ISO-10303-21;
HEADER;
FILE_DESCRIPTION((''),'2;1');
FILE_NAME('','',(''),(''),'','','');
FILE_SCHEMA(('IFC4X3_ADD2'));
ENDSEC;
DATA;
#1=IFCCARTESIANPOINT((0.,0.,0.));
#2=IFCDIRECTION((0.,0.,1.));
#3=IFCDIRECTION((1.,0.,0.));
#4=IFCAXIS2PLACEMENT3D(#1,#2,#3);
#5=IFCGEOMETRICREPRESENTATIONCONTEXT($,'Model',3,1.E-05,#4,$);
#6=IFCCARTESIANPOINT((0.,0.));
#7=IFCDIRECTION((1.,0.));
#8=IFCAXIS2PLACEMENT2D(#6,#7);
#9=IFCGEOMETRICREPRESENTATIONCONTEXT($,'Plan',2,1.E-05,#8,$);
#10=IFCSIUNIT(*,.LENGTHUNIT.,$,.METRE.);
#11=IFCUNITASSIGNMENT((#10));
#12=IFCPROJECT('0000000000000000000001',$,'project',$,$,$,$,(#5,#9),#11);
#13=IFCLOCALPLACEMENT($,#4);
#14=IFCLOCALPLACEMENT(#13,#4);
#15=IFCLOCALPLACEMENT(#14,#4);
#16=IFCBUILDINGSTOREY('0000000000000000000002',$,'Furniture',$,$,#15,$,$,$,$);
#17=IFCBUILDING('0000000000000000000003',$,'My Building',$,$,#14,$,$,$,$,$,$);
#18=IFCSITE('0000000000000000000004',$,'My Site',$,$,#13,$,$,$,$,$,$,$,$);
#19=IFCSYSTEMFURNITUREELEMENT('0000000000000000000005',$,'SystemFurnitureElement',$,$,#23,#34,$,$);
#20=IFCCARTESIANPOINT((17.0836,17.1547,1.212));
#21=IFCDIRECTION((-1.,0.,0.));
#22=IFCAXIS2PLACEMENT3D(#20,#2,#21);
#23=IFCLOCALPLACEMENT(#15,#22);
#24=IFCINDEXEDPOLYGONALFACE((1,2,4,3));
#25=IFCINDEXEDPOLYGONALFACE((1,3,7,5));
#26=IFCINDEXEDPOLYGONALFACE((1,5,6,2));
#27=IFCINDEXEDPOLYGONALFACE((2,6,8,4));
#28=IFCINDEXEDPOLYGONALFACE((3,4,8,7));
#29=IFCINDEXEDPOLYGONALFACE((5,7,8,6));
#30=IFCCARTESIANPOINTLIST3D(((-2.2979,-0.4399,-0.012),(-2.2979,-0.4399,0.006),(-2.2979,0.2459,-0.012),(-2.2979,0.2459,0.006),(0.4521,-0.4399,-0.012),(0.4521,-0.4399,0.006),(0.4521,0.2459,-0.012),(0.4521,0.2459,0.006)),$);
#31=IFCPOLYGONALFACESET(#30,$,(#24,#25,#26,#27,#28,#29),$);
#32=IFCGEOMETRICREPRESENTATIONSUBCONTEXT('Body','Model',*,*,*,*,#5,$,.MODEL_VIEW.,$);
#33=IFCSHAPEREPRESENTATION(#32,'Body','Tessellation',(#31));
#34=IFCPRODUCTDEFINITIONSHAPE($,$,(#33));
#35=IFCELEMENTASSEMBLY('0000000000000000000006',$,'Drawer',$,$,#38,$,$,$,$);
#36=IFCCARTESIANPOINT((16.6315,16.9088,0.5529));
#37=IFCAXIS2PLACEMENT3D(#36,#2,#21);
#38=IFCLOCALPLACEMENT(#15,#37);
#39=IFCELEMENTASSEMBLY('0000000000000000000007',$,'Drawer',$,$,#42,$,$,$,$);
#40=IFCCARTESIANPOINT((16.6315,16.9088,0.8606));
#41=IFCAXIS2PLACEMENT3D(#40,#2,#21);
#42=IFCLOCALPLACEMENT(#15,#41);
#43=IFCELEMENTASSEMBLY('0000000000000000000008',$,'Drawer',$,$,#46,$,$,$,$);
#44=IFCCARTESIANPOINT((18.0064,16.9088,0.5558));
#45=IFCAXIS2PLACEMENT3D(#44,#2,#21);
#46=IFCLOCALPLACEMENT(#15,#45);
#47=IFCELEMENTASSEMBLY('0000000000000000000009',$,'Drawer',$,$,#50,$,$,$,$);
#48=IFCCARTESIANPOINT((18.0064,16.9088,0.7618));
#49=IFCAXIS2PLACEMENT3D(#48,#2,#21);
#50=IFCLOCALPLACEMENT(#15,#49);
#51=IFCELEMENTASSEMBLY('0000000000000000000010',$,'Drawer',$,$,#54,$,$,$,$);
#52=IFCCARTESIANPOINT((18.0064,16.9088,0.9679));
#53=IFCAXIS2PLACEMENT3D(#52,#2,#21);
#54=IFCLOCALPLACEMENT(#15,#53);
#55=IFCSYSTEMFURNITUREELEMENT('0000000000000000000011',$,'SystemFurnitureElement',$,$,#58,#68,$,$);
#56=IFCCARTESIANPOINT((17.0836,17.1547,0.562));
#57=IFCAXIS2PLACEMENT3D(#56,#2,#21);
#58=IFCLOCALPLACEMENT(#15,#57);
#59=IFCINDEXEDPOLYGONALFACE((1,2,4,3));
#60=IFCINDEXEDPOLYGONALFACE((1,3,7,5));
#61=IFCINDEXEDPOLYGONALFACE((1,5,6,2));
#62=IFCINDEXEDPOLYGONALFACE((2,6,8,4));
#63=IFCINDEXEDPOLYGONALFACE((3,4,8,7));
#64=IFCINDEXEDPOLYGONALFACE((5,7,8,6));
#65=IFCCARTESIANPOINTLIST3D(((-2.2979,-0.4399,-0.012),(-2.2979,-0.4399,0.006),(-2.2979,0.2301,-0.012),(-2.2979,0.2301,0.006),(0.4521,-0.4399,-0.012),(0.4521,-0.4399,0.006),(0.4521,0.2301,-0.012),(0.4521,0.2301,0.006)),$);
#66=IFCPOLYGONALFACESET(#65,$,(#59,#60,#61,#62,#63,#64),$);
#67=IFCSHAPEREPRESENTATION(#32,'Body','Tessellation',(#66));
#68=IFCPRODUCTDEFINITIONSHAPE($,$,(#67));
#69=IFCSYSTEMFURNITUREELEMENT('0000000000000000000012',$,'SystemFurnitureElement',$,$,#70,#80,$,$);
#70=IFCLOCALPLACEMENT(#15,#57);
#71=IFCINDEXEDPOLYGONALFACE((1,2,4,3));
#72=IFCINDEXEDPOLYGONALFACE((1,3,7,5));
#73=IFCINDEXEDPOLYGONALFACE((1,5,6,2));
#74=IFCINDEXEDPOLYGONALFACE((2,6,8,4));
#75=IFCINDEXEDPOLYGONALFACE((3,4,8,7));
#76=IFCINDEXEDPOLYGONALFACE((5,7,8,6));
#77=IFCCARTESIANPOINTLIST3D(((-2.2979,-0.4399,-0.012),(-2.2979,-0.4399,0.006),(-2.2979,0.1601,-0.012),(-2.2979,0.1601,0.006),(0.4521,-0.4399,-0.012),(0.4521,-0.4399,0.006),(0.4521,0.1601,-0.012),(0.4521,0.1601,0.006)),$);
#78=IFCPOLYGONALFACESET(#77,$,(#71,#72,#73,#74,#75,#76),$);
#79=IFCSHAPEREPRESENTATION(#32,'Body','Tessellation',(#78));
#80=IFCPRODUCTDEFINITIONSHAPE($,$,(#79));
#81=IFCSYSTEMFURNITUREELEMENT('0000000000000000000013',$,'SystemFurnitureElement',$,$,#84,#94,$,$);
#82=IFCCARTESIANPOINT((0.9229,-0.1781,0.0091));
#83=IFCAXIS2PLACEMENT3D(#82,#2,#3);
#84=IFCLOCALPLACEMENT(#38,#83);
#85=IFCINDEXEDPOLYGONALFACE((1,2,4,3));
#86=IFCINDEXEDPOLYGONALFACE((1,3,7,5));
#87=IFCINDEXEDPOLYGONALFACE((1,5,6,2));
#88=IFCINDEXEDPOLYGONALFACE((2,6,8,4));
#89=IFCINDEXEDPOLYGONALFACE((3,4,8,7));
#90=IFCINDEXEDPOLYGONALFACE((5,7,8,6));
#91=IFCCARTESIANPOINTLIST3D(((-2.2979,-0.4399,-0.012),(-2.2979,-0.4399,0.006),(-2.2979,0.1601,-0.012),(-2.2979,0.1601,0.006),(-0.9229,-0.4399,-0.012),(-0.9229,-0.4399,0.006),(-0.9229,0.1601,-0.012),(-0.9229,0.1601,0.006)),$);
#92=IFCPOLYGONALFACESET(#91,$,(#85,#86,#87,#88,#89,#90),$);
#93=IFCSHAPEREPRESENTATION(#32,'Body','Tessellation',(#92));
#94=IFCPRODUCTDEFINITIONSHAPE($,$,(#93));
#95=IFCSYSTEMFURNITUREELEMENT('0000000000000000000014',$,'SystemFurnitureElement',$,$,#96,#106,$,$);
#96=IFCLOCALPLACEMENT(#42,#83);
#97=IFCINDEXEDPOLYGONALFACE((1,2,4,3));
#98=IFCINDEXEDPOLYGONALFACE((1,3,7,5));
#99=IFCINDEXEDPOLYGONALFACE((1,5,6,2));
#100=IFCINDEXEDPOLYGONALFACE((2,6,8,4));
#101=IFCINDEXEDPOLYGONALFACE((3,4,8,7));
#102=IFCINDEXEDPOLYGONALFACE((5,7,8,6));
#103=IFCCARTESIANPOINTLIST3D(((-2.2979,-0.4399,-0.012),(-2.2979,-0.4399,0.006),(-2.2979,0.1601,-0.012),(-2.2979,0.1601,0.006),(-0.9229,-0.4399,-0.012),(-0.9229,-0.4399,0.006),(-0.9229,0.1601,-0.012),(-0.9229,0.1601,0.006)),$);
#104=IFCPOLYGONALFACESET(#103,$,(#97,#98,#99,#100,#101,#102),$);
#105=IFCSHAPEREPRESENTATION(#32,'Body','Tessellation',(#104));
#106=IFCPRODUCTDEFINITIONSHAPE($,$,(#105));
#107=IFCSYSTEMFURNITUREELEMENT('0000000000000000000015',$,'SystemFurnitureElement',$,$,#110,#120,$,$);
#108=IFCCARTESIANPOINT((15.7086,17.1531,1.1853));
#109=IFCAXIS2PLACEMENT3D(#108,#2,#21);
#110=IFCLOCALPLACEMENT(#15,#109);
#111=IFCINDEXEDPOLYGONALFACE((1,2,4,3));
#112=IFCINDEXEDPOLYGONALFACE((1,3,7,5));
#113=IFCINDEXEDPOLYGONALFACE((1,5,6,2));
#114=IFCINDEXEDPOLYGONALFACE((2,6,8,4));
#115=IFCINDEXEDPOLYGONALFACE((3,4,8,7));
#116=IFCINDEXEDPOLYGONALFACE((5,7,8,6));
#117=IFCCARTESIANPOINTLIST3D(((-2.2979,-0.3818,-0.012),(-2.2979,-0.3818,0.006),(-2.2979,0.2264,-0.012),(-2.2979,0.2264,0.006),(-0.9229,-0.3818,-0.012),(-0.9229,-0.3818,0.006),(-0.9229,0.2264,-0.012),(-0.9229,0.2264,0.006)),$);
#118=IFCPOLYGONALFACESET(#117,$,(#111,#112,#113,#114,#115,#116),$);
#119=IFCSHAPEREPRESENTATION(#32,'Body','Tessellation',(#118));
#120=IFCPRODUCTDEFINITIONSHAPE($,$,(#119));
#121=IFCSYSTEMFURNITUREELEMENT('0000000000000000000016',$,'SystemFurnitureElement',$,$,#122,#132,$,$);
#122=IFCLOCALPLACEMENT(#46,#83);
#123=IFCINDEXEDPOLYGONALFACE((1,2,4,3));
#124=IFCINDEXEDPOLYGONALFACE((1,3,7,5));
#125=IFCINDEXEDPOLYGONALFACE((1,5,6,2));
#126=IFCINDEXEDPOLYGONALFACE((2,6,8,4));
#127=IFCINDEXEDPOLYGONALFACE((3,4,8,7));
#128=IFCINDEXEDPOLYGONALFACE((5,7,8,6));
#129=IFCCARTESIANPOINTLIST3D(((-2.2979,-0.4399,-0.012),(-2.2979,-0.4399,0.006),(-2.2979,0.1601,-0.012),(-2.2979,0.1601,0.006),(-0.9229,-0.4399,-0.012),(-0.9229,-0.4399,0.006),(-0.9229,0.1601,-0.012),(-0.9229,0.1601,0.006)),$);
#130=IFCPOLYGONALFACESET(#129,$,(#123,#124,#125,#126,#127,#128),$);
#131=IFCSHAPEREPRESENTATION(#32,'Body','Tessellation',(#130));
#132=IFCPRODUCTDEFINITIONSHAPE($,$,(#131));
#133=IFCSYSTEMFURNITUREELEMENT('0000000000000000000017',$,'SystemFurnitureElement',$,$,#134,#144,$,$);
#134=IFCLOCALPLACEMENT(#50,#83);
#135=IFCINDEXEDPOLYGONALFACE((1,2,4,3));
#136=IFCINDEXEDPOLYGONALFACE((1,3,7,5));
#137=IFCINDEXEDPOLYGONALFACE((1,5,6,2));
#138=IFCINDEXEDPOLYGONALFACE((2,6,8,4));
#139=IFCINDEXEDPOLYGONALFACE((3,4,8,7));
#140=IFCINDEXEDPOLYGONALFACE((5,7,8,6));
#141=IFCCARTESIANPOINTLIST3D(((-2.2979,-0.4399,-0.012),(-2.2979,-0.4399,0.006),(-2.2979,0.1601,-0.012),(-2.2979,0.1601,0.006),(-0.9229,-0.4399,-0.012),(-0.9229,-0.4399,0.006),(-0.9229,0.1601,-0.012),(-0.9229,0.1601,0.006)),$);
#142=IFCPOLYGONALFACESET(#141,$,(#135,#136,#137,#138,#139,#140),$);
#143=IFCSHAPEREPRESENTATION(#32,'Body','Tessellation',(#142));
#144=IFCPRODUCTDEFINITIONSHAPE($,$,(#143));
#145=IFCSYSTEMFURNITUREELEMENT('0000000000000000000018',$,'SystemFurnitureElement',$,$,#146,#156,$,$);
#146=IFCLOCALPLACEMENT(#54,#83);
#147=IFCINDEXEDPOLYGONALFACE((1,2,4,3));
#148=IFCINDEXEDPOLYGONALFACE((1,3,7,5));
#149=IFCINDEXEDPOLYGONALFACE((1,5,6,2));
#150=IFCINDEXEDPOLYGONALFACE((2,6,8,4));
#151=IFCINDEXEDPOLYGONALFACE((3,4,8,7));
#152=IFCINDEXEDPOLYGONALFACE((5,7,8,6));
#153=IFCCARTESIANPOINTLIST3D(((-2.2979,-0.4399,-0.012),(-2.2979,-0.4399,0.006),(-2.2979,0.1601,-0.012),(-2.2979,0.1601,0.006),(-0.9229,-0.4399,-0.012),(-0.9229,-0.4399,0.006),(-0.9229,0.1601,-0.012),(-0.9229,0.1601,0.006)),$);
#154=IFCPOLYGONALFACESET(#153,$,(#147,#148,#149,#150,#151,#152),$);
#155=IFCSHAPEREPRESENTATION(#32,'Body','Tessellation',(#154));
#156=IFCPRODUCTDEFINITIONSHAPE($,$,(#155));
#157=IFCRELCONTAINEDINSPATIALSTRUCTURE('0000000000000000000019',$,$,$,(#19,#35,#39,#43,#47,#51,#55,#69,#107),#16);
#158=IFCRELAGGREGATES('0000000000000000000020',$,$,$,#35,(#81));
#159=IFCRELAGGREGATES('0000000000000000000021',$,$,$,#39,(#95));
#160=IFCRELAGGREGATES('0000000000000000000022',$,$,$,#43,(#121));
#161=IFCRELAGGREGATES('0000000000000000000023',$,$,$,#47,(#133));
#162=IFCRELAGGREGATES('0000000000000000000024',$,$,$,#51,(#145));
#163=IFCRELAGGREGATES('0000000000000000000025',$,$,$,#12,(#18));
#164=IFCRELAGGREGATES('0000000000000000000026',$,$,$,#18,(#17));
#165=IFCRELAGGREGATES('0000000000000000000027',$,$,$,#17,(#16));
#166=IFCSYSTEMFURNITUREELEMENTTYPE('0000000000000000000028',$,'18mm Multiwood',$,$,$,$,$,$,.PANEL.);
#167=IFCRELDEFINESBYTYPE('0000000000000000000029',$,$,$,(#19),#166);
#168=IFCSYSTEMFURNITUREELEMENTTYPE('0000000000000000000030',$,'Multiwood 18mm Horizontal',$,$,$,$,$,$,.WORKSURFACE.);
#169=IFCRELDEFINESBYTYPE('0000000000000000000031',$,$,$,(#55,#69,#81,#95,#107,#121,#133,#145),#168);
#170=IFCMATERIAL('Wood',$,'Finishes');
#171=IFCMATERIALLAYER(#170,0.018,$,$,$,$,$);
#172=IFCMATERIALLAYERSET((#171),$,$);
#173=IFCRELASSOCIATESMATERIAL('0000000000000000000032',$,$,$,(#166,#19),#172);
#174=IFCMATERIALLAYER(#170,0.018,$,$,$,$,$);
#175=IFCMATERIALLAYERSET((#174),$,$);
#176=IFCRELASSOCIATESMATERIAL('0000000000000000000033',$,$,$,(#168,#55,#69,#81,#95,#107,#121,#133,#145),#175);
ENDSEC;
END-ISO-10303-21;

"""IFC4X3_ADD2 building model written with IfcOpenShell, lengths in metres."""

from ifc_helpers import new_model, si_unit, frame, origin_with_axes, origin_2d_with_axis, place, context, subcontext, project, spatial, indexed_curve, outline, extrude, material, layer, layer_set, layer_usage, type_object, element, aggregate, save


model = new_model("IFC4X3_ADD2")

# Units and contexts
model_context = context("Model", 3, precision=1e-05, world=origin_with_axes())
plan_context = context("Plan", 2, precision=1e-05, world=origin_2d_with_axis())
body_context = subcontext(model_context, "Body", "Model", "MODEL_VIEW")
ifc_project = project(units=[si_unit("LENGTHUNIT", "METRE")], contexts=[model_context, plan_context])

# Site, building, storey
site_placement = place(None, origin_with_axes())
site = spatial("IfcSite", under=ifc_project, at=site_placement, Name="My Site")
building_placement = place(site_placement, origin_with_axes())
building = spatial("IfcBuilding", under=site, at=building_placement, Name="My Building")
storey_placement = place(building_placement, origin_with_axes())
storey = spatial("IfcBuildingStorey", under=building, at=storey_placement, Name="Furniture")

# System furniture element
ifc_material_1 = material(Name="Wood", Category="Finishes")
ifc_layer_1 = layer(ifc_material_1, 0.018)
ifc_layer_set_1 = layer_set([ifc_layer_1])
system_furniture_element_type_1 = type_object("IfcSystemFurnitureElementType", Name="18mm Multiwood", PredefinedType="PANEL", material=ifc_layer_set_1)
ifc_layer_usage_1 = layer_usage(ifc_layer_set_1, "AXIS3", "POSITIVE", -0.012)
system_furniture_element_1_placement = place(storey_placement, frame((17.0836, 17.1547, 1.212), z_axis=(0.0, 0.0, 1.0), x_axis=(-1.0, 0.0, 0.0)))
element("IfcSystemFurnitureElement", 1, at=system_furniture_element_1_placement, inside=storey, type_object=system_furniture_element_type_1, material=ifc_layer_usage_1, Name="SystemFurnitureElement", context=body_context, shape_type="SweptSolid", body=[
    extrude(outline(indexed_curve([(0.4521, -0.4399), (0.4521, 0.2459), (-2.2979, 0.2459), (-2.2979, -0.4399), (0.4521, -0.4399)])), frame((0.0, 0.0, -0.012), z_axis=(0.0, 0.0, 1.0), x_axis=(1.0, 0.0, 0.0)), (0.0, 0.0, 1.0), 0.018),
])

# Element assemblies
assembly_1_placement = place(storey_placement, frame((16.6315, 16.9088, 0.5529), z_axis=(0.0, 0.0, 1.0), x_axis=(-1.0, 0.0, 0.0)))
assembly_1 = element("IfcElementAssembly", 2, at=assembly_1_placement, inside=storey, Name="Drawer")
assembly_2_placement = place(storey_placement, frame((16.6315, 16.9088, 0.8606), z_axis=(0.0, 0.0, 1.0), x_axis=(-1.0, 0.0, 0.0)))
assembly_2 = element("IfcElementAssembly", 3, at=assembly_2_placement, inside=storey, Name="Drawer")

# Element assemblies
assembly_3_placement = place(storey_placement, frame((18.0064, 16.9088, 0.5558), z_axis=(0.0, 0.0, 1.0), x_axis=(-1.0, 0.0, 0.0)))
assembly_3 = element("IfcElementAssembly", 4, at=assembly_3_placement, inside=storey, Name="Drawer")
assembly_4_placement = place(storey_placement, frame((18.0064, 16.9088, 0.7618), z_axis=(0.0, 0.0, 1.0), x_axis=(-1.0, 0.0, 0.0)))
assembly_4 = element("IfcElementAssembly", 5, at=assembly_4_placement, inside=storey, Name="Drawer")
assembly_5_placement = place(storey_placement, frame((18.0064, 16.9088, 0.9679), z_axis=(0.0, 0.0, 1.0), x_axis=(-1.0, 0.0, 0.0)))
assembly_5 = element("IfcElementAssembly", 6, at=assembly_5_placement, inside=storey, Name="Drawer")

# System furniture elements
ifc_layer_2 = layer(ifc_material_1, 0.018)
ifc_layer_set_2 = layer_set([ifc_layer_2])
ifc_layer_usage_2 = layer_usage(ifc_layer_set_2, "AXIS3", "POSITIVE", -0.012)
system_furniture_element_type_2 = type_object("IfcSystemFurnitureElementType", Name="Multiwood 18mm Horizontal", PredefinedType="WORKSURFACE", material=ifc_layer_set_2)
system_furniture_element_2_placement = place(storey_placement, frame((17.0836, 17.1547, 0.562), z_axis=(0.0, 0.0, 1.0), x_axis=(-1.0, 0.0, 0.0)))
element("IfcSystemFurnitureElement", 7, at=system_furniture_element_2_placement, inside=storey, type_object=system_furniture_element_type_2, material=ifc_layer_usage_2, Name="SystemFurnitureElement", context=body_context, shape_type="SweptSolid", body=[
    extrude(outline(indexed_curve([(-2.2979, -0.4399), (-2.2979, 0.2301), (0.4521, 0.2301), (0.4521, -0.4399), (-2.2979, -0.4399)])), frame((0.0, 0.0, -0.012), z_axis=(0.0, 0.0, 1.0), x_axis=(1.0, 0.0, 0.0)), (0.0, 0.0, 1.0), 0.018),
])
ifc_layer_usage_3 = layer_usage(ifc_layer_set_2, "AXIS3", "POSITIVE", -0.012)
system_furniture_element_3_placement = place(storey_placement, frame((17.0836, 17.1547, 0.562), z_axis=(0.0, 0.0, 1.0), x_axis=(-1.0, 0.0, 0.0)))
element("IfcSystemFurnitureElement", 8, at=system_furniture_element_3_placement, inside=storey, type_object=system_furniture_element_type_2, material=ifc_layer_usage_3, Name="SystemFurnitureElement", context=body_context, shape_type="SweptSolid", body=[
    extrude(outline(indexed_curve([(0.4521, -0.4399), (0.4521, 0.1601), (-2.2979, 0.1601), (-2.2979, -0.4399), (0.4521, -0.4399)])), frame((0.0, 0.0, -0.012), z_axis=(0.0, 0.0, 1.0), x_axis=(1.0, 0.0, 0.0)), (0.0, 0.0, 1.0), 0.018),
])

# System furniture elements
ifc_layer_usage_4 = layer_usage(ifc_layer_set_2, "AXIS3", "POSITIVE", -0.012)
system_furniture_element_4_placement = place(assembly_1_placement, frame((0.9229, -0.1781, 0.0091), z_axis=(0.0, 0.0, 1.0), x_axis=(1.0, 0.0, 0.0)))
system_furniture_element_4 = element("IfcSystemFurnitureElement", 9, at=system_furniture_element_4_placement, type_object=system_furniture_element_type_2, material=ifc_layer_usage_4, Name="SystemFurnitureElement", context=body_context, shape_type="SweptSolid", body=[
    extrude(outline(indexed_curve([(-2.2979, -0.4399), (-2.2979, 0.1601), (-0.9229, 0.1601), (-0.9229, -0.4399), (-2.2979, -0.4399)])), frame((0.0, 0.0, -0.012), z_axis=(0.0, 0.0, 1.0), x_axis=(1.0, 0.0, 0.0)), (0.0, 0.0, 1.0), 0.018),
])
aggregate(assembly_1, [system_furniture_element_4])
ifc_layer_usage_5 = layer_usage(ifc_layer_set_2, "AXIS3", "POSITIVE", -0.012)
system_furniture_element_5_placement = place(assembly_2_placement, frame((0.9229, -0.1781, 0.0091), z_axis=(0.0, 0.0, 1.0), x_axis=(1.0, 0.0, 0.0)))
system_furniture_element_5 = element("IfcSystemFurnitureElement", 10, at=system_furniture_element_5_placement, type_object=system_furniture_element_type_2, material=ifc_layer_usage_5, Name="SystemFurnitureElement", context=body_context, shape_type="SweptSolid", body=[
    extrude(outline(indexed_curve([(-2.2979, -0.4399), (-2.2979, 0.1601), (-0.9229, 0.1601), (-0.9229, -0.4399), (-2.2979, -0.4399)])), frame((0.0, 0.0, -0.012), z_axis=(0.0, 0.0, 1.0), x_axis=(1.0, 0.0, 0.0)), (0.0, 0.0, 1.0), 0.018),
])
ifc_layer_usage_6 = layer_usage(ifc_layer_set_2, "AXIS3", "POSITIVE", -0.012)
system_furniture_element_6_placement = place(storey_placement, frame((15.7086, 17.1531, 1.1853), z_axis=(0.0, 0.0, 1.0), x_axis=(-1.0, 0.0, 0.0)))
element("IfcSystemFurnitureElement", 11, at=system_furniture_element_6_placement, inside=storey, type_object=system_furniture_element_type_2, material=ifc_layer_usage_6, Name="SystemFurnitureElement", context=body_context, shape_type="SweptSolid", body=[
    extrude(outline(indexed_curve([(-2.2979, -0.3818), (-2.2979, 0.2264), (-0.9229, 0.2264), (-0.9229, -0.3818), (-2.2979, -0.3818)])), frame((0.0, 0.0, -0.012), z_axis=(0.0, 0.0, 1.0), x_axis=(1.0, 0.0, 0.0)), (0.0, 0.0, 1.0), 0.018),
])
ifc_layer_usage_7 = layer_usage(ifc_layer_set_2, "AXIS3", "POSITIVE", -0.012)
system_furniture_element_7_placement = place(assembly_3_placement, frame((0.9229, -0.1781, 0.0091), z_axis=(0.0, 0.0, 1.0), x_axis=(1.0, 0.0, 0.0)))
system_furniture_element_7 = element("IfcSystemFurnitureElement", 12, at=system_furniture_element_7_placement, type_object=system_furniture_element_type_2, material=ifc_layer_usage_7, Name="SystemFurnitureElement", context=body_context, shape_type="SweptSolid", body=[
    extrude(outline(indexed_curve([(-2.2979, -0.4399), (-2.2979, 0.1601), (-0.9229, 0.1601), (-0.9229, -0.4399), (-2.2979, -0.4399)])), frame((0.0, 0.0, -0.012), z_axis=(0.0, 0.0, 1.0), x_axis=(1.0, 0.0, 0.0)), (0.0, 0.0, 1.0), 0.018),
])
ifc_layer_usage_8 = layer_usage(ifc_layer_set_2, "AXIS3", "POSITIVE", -0.012)
system_furniture_element_8_placement = place(assembly_4_placement, frame((0.9229, -0.1781, 0.0091), z_axis=(0.0, 0.0, 1.0), x_axis=(1.0, 0.0, 0.0)))
system_furniture_element_8 = element("IfcSystemFurnitureElement", 13, at=system_furniture_element_8_placement, type_object=system_furniture_element_type_2, material=ifc_layer_usage_8, Name="SystemFurnitureElement", context=body_context, shape_type="SweptSolid", body=[
    extrude(outline(indexed_curve([(-2.2979, -0.4399), (-2.2979, 0.1601), (-0.9229, 0.1601), (-0.9229, -0.4399), (-2.2979, -0.4399)])), frame((0.0, 0.0, -0.012), z_axis=(0.0, 0.0, 1.0), x_axis=(1.0, 0.0, 0.0)), (0.0, 0.0, 1.0), 0.018),
])
ifc_layer_usage_9 = layer_usage(ifc_layer_set_2, "AXIS3", "POSITIVE", -0.012)
system_furniture_element_9_placement = place(assembly_5_placement, frame((0.9229, -0.1781, 0.0091), z_axis=(0.0, 0.0, 1.0), x_axis=(1.0, 0.0, 0.0)))
system_furniture_element_9 = element("IfcSystemFurnitureElement", 14, at=system_furniture_element_9_placement, type_object=system_furniture_element_type_2, material=ifc_layer_usage_9, Name="SystemFurnitureElement", context=body_context, shape_type="SweptSolid", body=[
    extrude(outline(indexed_curve([(-2.2979, -0.4399), (-2.2979, 0.1601), (-0.9229, 0.1601), (-0.9229, -0.4399), (-2.2979, -0.4399)])), frame((0.0, 0.0, -0.012), z_axis=(0.0, 0.0, 1.0), x_axis=(1.0, 0.0, 0.0)), (0.0, 0.0, 1.0), 0.018),
])
aggregate(assembly_2, [system_furniture_element_5])
aggregate(assembly_3, [system_furniture_element_7])
aggregate(assembly_4, [system_furniture_element_8])
aggregate(assembly_5, [system_furniture_element_9])

save(model, "model.ifc")
